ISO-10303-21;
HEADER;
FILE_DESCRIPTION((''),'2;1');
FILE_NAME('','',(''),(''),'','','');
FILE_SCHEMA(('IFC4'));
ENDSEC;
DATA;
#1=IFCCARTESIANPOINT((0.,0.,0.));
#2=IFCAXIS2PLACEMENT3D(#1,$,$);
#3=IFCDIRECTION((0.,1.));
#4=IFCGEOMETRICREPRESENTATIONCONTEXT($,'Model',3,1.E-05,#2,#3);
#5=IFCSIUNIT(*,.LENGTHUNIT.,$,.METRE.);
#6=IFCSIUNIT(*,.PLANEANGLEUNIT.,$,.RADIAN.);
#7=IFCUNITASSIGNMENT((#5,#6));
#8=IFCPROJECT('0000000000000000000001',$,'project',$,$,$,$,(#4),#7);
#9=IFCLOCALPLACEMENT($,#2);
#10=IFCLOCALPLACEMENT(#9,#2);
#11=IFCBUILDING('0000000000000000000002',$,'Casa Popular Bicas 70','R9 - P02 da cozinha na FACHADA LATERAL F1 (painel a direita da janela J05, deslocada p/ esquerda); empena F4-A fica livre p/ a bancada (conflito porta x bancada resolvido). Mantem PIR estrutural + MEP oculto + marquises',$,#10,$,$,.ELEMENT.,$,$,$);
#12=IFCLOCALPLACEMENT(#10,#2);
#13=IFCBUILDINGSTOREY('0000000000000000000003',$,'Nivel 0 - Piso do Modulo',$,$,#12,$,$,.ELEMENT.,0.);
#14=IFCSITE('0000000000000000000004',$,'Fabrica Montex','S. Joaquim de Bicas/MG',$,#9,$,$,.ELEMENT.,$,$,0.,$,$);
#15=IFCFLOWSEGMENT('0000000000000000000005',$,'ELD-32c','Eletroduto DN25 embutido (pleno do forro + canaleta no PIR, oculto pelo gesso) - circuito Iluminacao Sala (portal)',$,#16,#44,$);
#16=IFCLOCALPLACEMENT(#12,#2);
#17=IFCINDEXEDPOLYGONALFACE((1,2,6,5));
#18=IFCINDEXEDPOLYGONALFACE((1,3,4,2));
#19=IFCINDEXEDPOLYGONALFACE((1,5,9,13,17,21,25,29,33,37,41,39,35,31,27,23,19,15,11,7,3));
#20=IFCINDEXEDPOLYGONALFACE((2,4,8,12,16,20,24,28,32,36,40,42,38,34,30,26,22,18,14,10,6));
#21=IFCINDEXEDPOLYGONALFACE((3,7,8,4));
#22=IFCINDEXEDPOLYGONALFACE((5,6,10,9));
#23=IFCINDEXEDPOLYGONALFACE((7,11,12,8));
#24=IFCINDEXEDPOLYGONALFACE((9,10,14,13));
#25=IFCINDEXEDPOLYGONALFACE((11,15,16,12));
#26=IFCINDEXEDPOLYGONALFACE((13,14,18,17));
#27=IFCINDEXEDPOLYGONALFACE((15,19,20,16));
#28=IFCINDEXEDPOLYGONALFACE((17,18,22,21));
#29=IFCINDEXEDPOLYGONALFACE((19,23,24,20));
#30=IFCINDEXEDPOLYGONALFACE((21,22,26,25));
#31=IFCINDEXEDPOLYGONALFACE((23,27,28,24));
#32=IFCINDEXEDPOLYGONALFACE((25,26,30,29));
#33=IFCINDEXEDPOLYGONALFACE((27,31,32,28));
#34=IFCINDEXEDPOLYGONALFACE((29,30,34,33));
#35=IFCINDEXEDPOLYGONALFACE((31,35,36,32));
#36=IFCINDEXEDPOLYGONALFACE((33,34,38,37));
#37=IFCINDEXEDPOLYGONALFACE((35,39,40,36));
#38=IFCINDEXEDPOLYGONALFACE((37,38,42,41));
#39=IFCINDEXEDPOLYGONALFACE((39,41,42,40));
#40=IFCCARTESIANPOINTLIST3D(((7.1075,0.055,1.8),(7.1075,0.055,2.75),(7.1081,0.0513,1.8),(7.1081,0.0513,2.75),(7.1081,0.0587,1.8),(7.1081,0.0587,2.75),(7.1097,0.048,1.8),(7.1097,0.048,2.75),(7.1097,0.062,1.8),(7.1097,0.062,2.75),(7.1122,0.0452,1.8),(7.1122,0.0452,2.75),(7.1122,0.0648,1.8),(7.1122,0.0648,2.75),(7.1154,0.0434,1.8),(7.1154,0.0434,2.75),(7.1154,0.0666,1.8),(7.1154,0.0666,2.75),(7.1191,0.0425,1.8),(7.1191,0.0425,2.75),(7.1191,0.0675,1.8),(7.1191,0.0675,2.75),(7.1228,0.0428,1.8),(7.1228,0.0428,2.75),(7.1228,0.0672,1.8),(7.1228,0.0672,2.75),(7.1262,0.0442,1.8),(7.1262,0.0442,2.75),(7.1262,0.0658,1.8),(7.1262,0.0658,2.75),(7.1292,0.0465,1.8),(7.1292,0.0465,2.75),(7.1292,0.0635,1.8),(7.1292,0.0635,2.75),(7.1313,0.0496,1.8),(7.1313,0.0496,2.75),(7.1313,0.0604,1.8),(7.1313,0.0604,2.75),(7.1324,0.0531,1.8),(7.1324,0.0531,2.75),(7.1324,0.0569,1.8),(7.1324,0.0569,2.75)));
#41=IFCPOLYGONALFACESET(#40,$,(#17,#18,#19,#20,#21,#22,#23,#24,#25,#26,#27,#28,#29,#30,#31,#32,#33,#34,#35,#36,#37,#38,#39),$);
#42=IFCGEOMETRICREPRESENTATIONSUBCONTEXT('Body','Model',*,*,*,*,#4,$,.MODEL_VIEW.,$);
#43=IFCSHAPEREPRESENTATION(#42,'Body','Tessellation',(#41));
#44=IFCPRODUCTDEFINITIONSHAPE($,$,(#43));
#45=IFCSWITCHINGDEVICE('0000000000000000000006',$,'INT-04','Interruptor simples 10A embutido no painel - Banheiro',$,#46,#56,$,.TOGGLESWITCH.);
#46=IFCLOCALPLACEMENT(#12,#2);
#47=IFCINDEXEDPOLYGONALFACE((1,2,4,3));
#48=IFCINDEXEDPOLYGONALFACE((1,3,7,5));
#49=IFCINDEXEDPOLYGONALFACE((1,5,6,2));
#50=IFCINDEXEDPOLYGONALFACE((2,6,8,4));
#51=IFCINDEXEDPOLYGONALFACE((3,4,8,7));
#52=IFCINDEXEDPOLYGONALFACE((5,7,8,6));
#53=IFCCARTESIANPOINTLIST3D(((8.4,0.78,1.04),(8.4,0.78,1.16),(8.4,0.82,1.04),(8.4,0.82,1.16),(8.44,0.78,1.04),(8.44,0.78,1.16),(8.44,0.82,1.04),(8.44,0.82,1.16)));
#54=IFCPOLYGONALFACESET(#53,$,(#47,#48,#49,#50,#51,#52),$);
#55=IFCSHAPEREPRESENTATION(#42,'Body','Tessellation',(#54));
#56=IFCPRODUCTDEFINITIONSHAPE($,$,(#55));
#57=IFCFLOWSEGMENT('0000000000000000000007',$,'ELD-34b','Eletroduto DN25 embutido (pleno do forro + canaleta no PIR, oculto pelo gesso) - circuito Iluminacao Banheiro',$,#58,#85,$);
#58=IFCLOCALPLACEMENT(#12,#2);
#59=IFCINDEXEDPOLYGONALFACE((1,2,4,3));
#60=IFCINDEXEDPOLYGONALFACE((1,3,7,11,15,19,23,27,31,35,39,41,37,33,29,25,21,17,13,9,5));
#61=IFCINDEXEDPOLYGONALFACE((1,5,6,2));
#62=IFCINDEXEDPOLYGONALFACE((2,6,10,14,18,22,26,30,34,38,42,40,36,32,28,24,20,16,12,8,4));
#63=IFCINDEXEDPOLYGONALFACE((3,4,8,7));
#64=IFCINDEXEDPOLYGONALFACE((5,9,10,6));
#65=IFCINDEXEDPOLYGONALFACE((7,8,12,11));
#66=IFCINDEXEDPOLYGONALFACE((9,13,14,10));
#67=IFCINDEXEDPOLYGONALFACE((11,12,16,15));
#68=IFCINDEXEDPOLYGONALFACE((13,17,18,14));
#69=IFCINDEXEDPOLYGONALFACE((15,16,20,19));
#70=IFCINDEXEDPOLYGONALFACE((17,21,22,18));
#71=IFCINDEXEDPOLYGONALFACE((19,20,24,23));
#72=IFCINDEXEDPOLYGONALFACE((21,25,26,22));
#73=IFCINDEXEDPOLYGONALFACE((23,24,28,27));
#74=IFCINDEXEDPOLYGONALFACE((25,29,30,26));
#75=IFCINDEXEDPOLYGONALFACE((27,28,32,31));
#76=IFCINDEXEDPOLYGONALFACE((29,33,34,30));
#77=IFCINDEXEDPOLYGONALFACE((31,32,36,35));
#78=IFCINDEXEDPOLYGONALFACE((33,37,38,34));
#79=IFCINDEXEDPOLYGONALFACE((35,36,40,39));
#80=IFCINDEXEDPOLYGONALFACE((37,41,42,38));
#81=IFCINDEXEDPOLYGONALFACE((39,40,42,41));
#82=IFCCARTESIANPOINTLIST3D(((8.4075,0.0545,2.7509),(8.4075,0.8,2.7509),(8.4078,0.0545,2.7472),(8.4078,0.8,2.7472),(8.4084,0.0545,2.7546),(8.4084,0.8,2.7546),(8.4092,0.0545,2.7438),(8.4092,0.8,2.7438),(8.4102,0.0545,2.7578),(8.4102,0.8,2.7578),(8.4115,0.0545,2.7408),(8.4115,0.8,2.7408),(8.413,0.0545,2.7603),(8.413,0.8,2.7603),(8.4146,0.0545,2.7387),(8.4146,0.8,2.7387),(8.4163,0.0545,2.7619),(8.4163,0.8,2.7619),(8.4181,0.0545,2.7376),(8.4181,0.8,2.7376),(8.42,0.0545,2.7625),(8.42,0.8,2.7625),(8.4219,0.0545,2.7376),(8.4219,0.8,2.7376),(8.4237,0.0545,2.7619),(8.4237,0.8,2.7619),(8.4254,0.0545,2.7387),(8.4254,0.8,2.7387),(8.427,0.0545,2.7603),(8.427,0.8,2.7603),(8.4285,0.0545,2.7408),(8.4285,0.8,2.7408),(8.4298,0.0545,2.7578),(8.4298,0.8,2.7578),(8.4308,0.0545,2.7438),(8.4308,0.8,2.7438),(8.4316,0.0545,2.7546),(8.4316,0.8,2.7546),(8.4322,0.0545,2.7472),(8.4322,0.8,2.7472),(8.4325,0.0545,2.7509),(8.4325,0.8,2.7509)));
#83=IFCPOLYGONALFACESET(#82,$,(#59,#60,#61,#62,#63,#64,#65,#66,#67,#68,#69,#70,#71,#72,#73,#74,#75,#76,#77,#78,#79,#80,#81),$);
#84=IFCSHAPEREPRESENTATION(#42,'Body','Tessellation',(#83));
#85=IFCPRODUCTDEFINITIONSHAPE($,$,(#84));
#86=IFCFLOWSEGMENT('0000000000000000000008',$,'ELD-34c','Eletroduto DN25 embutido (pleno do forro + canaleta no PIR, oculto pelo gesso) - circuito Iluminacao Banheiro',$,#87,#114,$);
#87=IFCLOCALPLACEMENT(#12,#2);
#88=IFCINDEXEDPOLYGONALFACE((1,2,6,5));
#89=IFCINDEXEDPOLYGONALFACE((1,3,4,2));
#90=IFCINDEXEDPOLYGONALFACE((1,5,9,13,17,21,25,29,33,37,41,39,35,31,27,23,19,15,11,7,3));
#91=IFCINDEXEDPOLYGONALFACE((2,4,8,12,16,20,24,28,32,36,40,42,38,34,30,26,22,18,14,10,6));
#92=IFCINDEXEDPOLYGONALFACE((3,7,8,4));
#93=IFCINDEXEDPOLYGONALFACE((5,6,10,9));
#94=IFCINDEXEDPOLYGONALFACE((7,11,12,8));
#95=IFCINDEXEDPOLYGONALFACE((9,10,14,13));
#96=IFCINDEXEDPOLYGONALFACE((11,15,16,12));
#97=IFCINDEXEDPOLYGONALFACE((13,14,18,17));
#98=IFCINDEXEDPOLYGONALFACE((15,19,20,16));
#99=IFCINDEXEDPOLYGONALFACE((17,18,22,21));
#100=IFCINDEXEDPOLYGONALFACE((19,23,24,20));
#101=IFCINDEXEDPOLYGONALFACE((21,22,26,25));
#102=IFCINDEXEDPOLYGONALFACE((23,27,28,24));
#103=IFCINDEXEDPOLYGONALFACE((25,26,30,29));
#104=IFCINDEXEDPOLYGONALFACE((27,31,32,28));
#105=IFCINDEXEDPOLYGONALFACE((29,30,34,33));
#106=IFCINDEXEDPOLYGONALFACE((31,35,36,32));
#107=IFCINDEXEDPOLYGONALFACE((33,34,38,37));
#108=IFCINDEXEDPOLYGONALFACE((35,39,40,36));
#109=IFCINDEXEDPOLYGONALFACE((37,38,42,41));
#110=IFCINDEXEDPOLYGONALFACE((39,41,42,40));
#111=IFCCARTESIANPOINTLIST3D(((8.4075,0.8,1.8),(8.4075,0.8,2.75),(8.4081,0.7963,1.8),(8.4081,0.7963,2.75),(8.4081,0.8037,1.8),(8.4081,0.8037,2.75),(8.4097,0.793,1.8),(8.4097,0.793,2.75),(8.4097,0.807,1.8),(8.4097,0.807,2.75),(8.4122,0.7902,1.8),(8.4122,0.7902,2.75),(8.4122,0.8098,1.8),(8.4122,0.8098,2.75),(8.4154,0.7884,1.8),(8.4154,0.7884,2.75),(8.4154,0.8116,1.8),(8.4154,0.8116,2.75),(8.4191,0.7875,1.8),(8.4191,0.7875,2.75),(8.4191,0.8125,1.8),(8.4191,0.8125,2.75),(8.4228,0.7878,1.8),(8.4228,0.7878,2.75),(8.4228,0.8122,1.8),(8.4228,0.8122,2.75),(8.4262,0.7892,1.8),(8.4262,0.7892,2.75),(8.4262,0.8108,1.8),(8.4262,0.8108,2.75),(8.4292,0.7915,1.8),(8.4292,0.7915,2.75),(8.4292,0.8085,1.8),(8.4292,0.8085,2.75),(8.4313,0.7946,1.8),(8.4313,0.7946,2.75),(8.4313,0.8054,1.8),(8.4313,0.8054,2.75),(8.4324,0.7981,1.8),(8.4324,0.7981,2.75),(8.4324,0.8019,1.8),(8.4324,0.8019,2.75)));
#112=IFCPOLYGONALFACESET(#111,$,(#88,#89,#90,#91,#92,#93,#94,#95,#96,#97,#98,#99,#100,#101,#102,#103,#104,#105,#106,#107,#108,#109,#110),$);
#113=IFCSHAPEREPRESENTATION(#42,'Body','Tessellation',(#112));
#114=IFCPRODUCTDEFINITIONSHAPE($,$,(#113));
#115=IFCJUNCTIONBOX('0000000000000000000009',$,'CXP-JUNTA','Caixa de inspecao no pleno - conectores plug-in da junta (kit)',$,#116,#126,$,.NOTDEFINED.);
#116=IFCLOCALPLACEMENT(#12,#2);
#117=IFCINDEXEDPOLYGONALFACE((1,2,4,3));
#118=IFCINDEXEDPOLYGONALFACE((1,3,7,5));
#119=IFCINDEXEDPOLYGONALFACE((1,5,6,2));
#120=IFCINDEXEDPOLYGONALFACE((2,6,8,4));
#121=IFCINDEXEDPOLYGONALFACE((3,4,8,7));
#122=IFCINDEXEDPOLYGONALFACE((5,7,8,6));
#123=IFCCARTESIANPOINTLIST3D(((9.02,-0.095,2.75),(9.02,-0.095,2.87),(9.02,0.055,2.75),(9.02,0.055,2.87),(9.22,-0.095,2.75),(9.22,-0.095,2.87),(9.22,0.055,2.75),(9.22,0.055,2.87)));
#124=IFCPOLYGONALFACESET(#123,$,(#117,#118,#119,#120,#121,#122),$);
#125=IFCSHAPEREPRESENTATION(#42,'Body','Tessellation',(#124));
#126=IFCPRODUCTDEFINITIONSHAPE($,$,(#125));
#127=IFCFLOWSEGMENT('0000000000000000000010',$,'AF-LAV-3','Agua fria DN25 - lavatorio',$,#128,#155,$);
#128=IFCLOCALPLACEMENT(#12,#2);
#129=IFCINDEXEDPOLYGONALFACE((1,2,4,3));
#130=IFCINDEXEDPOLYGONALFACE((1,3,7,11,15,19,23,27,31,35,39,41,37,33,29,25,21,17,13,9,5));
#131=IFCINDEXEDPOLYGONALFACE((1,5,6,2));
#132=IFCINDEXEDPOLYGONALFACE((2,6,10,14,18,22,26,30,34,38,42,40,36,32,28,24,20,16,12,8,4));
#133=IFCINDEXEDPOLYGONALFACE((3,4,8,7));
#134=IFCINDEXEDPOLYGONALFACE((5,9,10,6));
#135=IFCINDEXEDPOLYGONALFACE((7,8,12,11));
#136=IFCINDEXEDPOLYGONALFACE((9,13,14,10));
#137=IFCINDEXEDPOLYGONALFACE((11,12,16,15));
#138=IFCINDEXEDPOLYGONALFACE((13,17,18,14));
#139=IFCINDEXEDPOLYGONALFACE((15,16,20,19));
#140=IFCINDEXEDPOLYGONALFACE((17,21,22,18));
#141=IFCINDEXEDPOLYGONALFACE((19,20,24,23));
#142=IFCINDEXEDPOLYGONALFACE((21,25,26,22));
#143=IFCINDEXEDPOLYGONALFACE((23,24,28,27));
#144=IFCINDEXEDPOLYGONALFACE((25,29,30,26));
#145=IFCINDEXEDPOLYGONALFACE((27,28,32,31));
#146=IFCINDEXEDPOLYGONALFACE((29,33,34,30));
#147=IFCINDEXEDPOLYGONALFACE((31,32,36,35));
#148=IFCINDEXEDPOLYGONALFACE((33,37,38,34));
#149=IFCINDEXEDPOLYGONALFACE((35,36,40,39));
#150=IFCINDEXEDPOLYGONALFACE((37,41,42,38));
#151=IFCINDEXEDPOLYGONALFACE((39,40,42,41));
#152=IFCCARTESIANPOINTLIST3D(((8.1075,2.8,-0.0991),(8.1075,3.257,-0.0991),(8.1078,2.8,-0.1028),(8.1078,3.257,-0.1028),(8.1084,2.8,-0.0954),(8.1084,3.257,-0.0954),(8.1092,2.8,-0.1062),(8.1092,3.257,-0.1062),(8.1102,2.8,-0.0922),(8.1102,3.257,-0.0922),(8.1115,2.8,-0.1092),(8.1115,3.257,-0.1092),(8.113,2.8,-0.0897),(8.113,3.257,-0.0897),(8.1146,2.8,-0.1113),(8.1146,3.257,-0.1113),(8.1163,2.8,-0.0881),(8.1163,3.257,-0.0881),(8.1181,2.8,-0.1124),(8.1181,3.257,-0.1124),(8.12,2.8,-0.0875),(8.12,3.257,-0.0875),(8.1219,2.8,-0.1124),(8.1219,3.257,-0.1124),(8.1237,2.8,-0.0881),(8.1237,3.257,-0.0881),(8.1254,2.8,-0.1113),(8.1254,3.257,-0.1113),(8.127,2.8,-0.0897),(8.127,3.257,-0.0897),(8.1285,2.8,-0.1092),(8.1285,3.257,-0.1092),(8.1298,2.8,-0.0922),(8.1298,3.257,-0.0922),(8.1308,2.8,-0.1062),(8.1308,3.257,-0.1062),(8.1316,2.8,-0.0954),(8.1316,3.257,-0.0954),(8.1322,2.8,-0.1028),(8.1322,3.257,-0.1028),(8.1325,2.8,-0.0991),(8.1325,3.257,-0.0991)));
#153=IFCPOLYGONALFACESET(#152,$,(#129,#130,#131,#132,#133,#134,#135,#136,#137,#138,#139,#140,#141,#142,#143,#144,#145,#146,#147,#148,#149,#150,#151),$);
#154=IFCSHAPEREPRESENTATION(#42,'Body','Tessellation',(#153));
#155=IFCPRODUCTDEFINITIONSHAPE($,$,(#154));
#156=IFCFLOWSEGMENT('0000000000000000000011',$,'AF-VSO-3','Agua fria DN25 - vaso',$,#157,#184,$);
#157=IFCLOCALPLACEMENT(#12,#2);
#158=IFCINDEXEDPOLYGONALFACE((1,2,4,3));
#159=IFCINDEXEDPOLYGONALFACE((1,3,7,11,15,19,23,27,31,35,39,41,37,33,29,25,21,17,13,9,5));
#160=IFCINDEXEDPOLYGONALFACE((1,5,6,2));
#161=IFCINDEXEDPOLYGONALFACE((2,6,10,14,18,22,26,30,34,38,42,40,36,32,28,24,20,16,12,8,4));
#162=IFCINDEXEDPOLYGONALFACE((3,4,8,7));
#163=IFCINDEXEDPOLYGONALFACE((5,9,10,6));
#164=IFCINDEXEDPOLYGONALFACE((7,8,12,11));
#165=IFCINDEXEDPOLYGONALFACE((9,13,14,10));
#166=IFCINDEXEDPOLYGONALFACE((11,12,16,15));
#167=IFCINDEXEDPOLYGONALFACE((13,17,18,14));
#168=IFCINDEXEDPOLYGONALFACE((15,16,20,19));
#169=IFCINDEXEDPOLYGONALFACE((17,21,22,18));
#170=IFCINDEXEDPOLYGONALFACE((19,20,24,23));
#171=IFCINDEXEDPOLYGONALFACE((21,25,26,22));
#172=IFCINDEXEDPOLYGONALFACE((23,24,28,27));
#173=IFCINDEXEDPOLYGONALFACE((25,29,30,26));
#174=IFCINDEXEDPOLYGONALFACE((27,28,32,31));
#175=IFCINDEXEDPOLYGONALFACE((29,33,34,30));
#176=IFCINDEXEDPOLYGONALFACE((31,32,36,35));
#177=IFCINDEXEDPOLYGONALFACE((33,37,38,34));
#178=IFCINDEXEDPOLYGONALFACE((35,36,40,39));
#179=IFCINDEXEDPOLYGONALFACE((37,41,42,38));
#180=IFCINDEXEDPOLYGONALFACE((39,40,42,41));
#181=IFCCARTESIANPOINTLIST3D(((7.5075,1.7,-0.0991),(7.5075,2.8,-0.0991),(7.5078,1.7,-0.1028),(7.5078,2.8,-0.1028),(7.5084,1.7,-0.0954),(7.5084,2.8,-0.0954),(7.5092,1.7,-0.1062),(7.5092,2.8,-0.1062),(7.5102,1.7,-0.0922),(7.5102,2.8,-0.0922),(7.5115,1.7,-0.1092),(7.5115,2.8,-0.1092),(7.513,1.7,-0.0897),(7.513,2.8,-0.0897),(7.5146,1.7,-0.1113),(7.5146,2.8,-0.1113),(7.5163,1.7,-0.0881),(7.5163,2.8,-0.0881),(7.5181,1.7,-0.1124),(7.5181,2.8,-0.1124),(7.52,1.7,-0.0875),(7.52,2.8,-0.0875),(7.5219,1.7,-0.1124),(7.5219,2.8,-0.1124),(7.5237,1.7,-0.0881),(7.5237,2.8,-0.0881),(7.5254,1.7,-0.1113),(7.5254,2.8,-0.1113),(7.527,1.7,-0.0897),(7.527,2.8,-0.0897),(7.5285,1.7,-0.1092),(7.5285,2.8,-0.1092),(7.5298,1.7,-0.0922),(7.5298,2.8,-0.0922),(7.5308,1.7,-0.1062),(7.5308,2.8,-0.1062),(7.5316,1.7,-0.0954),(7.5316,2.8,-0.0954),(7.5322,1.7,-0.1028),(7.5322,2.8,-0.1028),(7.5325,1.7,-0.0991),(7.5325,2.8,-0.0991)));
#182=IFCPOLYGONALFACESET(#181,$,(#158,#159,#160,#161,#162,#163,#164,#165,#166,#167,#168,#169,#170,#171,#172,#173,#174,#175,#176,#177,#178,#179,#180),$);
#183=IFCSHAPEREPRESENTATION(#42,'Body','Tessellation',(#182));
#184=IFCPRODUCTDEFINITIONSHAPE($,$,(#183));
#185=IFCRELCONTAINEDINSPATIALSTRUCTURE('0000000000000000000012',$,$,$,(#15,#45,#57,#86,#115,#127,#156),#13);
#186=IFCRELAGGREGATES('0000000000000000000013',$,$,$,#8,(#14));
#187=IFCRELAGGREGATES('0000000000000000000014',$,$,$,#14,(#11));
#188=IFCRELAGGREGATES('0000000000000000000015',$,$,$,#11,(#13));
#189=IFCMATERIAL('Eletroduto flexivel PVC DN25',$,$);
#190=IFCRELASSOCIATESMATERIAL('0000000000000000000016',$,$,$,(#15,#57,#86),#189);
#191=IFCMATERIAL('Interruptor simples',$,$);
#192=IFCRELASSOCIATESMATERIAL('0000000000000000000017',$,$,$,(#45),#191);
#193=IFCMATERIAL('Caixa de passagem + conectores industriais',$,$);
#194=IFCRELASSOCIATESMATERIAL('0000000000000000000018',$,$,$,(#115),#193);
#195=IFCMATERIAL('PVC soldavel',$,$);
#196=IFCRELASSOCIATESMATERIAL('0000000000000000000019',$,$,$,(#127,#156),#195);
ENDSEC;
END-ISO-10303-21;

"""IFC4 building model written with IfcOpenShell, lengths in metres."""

from ifc_helpers import new_model, si_unit, direction, frame, frame_2d, origin, origin_2d, place, context, subcontext, project, spatial, rectangle, circle, extrude, material, element, save


model = new_model("IFC4")

# Units and contexts
model_context = context("Model", 3, precision=1e-05, world=origin(), true_north=direction((0.0, 1.0)))
body_context = subcontext(model_context, "Body", "Model", "MODEL_VIEW")
ifc_project = project(units=[si_unit("LENGTHUNIT", "METRE"), si_unit("PLANEANGLEUNIT", "RADIAN")], contexts=[model_context])

# Site, building, storey
site_placement = place(None, origin())
site = spatial("IfcSite", under=ifc_project, at=site_placement, Name="Fabrica Montex", Description="S. Joaquim de Bicas/MG", CompositionType="ELEMENT", RefElevation=0.0)
building_placement = place(site_placement, origin())
building = spatial("IfcBuilding", under=site, at=building_placement, Name="Casa Popular Bicas 70", Description="R9 - P02 da cozinha na FACHADA LATERAL F1 (painel a direita da janela J05, deslocada p/ esquerda); empena F4-A fica livre p/ a bancada (conflito porta x bancada resolvido). Mantem PIR estrutural + MEP oculto + marquises", CompositionType="ELEMENT")
storey_placement = place(building_placement, origin())
storey = spatial("IfcBuildingStorey", under=building, at=storey_placement, Name="Nivel 0 - Piso do Modulo", CompositionType="ELEMENT", Elevation=0.0)

# Shared definitions
ifc_material_1 = material(Name="Eletroduto flexivel PVC DN25")

# Flow segment
flow_segment_1_placement = place(None, frame((7.12, 0.055, 2.75), z_axis=(0.0, 0.0, -1.0), x_axis=(-1.0, 0.0, 0.0)))
element("IfcFlowSegment", 1, at=flow_segment_1_placement, inside=storey, material=ifc_material_1, Name="ELD-32c", Description="Eletroduto DN25 embutido (pleno do forro + canaleta no PIR, oculto pelo gesso) - circuito Iluminacao Sala (portal)", context=body_context, shape_type="SweptSolid", body=[
    extrude(circle(Radius=0.0125, at=origin_2d()), origin(), (0.0, 0.0, 1.0), 0.95),
])

# Switching device
ifc_material_2 = material(Name="Interruptor simples")
switching_device_1_placement = place(None, frame((8.44, 0.82, 1.04), z_axis=(0.0, 0.0, 1.0), x_axis=(-1.0, 0.0, 0.0)))
element("IfcSwitchingDevice", 2, at=switching_device_1_placement, inside=storey, material=ifc_material_2, Name="INT-04", Description="Interruptor simples 10A embutido no painel - Banheiro", PredefinedType="TOGGLESWITCH", context=body_context, shape_type="SweptSolid", body=[
    extrude(rectangle(XDim=0.04, YDim=0.04, at=frame_2d((0.02, 0.02))), origin(), (0.0, 0.0, 1.0), 0.12),
])

# Flow segments
flow_segment_2_placement = place(None, frame((8.42, 0.0545, 2.75), z_axis=(0.0, 1.0, 0.0), x_axis=(0.0, 0.0, 1.0)))
element("IfcFlowSegment", 3, at=flow_segment_2_placement, inside=storey, material=ifc_material_1, Name="ELD-34b", Description="Eletroduto DN25 embutido (pleno do forro + canaleta no PIR, oculto pelo gesso) - circuito Iluminacao Banheiro", context=body_context, shape_type="SweptSolid", body=[
    extrude(circle(Radius=0.0125, at=origin_2d()), origin(), (0.0, 0.0, 1.0), 0.7455),
])
flow_segment_3_placement = place(None, frame((8.42, 0.8, 2.75), z_axis=(0.0, 0.0, -1.0), x_axis=(-1.0, 0.0, 0.0)))
element("IfcFlowSegment", 4, at=flow_segment_3_placement, inside=storey, material=ifc_material_1, Name="ELD-34c", Description="Eletroduto DN25 embutido (pleno do forro + canaleta no PIR, oculto pelo gesso) - circuito Iluminacao Banheiro", context=body_context, shape_type="SweptSolid", body=[
    extrude(circle(Radius=0.0125, at=origin_2d()), origin(), (0.0, 0.0, 1.0), 0.95),
])

# Junction box
ifc_material_3 = material(Name="Caixa de passagem + conectores industriais")
junction_box_placement = place(None, frame((9.22, 0.055, 2.75), z_axis=(0.0, 0.0, 1.0), x_axis=(-1.0, 0.0, 0.0)))
element("IfcJunctionBox", 5, at=junction_box_placement, inside=storey, material=ifc_material_3, Name="CXP-JUNTA", Description="Caixa de inspecao no pleno - conectores plug-in da junta (kit)", PredefinedType="NOTDEFINED", context=body_context, shape_type="SweptSolid", body=[
    extrude(rectangle(XDim=0.2, YDim=0.15, at=frame_2d((0.1, 0.075))), origin(), (0.0, 0.0, 1.0), 0.12),
])

# Flow segments
ifc_material_4 = material(Name="PVC soldavel")
flow_segment_4_placement = place(None, frame((8.12, 2.8, -0.1), z_axis=(0.0, 1.0, 0.0), x_axis=(0.0, 0.0, 1.0)))
element("IfcFlowSegment", 6, at=flow_segment_4_placement, inside=storey, material=ifc_material_4, Name="AF-LAV-3", Description="Agua fria DN25 - lavatorio", context=body_context, shape_type="SweptSolid", body=[
    extrude(circle(Radius=0.0125, at=origin_2d()), origin(), (0.0, 0.0, 1.0), 0.457),
])
flow_segment_5_placement = place(None, frame((7.52, 2.8, -0.1), z_axis=(0.0, -1.0, 0.0), x_axis=(0.0, 0.0, 1.0)))
element("IfcFlowSegment", 7, at=flow_segment_5_placement, inside=storey, material=ifc_material_4, Name="AF-VSO-3", Description="Agua fria DN25 - vaso", context=body_context, shape_type="SweptSolid", body=[
    extrude(circle(Radius=0.0125, at=origin_2d()), origin(), (0.0, 0.0, 1.0), 1.1),
])

save(model, "model.ifc")
